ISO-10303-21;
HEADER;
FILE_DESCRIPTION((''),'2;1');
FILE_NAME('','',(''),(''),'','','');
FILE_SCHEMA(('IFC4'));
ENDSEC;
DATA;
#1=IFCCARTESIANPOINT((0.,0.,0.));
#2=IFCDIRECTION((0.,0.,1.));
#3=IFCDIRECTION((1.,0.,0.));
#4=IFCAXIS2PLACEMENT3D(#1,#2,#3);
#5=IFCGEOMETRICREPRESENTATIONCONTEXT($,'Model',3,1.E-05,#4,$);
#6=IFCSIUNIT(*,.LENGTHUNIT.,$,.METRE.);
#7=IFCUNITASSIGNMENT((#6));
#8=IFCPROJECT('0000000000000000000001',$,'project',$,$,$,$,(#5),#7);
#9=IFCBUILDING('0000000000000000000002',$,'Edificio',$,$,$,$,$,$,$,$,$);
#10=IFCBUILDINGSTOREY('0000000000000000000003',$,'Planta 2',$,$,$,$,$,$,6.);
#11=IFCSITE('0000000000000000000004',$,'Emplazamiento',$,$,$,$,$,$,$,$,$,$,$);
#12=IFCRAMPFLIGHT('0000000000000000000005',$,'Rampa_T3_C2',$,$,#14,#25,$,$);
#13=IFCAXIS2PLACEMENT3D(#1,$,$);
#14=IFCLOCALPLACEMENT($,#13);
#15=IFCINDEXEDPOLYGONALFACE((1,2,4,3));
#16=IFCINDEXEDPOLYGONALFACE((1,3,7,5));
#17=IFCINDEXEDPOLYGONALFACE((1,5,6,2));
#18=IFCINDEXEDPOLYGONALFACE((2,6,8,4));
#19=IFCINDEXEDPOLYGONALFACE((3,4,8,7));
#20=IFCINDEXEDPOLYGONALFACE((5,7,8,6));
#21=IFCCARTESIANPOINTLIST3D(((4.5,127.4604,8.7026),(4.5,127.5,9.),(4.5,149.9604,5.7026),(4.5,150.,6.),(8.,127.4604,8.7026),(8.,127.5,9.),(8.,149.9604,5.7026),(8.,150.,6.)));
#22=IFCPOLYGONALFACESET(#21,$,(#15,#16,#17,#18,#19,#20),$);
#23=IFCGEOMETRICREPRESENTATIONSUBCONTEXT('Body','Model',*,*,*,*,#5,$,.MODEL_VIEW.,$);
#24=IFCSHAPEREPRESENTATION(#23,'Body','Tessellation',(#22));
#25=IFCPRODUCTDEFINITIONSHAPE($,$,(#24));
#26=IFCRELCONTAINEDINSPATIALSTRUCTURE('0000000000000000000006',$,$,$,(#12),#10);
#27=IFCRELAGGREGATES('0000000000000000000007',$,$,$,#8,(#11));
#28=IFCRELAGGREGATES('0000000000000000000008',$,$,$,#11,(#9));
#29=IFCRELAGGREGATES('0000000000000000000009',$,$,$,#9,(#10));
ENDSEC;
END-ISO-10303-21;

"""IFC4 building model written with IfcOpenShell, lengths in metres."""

from ifc_helpers import new_model, si_unit, frame, origin_with_axes, origin_2d, place, context, subcontext, project, spatial, rectangle, extrude, element, save


model = new_model("IFC4")

# Units and contexts
model_context = context("Model", 3, precision=1e-05, world=origin_with_axes())
body_context = subcontext(model_context, "Body", "Model", "MODEL_VIEW")
ifc_project = project(units=[si_unit("LENGTHUNIT", "METRE")], contexts=[model_context])

# Site, building, storey
site = spatial("IfcSite", under=ifc_project, Name="Emplazamiento")
building = spatial("IfcBuilding", under=site, Name="Edificio")
storey = spatial("IfcBuildingStorey", under=building, Name="Planta 2", Elevation=6.0)

# Ramp flight
for number, where, z_axis, x_axis, name in (
    (1, (6.25, 138.7104, 7.2026), (0.0, 0.132164, 0.991228), (0.0, -0.991228, 0.132164), "Rampa_T3_C2"),
):
    element("IfcRampFlight", number, at=place(None, frame(where, z_axis=z_axis, x_axis=x_axis)), inside=storey, Name=name, context=body_context, shape_type="SweptSolid", body=[
        extrude(rectangle(XDim=22.6991, YDim=3.5, at=origin_2d()), origin_with_axes(), (0.0, 0.0, 1.0), 0.3),
    ])

save(model, "model.ifc")
